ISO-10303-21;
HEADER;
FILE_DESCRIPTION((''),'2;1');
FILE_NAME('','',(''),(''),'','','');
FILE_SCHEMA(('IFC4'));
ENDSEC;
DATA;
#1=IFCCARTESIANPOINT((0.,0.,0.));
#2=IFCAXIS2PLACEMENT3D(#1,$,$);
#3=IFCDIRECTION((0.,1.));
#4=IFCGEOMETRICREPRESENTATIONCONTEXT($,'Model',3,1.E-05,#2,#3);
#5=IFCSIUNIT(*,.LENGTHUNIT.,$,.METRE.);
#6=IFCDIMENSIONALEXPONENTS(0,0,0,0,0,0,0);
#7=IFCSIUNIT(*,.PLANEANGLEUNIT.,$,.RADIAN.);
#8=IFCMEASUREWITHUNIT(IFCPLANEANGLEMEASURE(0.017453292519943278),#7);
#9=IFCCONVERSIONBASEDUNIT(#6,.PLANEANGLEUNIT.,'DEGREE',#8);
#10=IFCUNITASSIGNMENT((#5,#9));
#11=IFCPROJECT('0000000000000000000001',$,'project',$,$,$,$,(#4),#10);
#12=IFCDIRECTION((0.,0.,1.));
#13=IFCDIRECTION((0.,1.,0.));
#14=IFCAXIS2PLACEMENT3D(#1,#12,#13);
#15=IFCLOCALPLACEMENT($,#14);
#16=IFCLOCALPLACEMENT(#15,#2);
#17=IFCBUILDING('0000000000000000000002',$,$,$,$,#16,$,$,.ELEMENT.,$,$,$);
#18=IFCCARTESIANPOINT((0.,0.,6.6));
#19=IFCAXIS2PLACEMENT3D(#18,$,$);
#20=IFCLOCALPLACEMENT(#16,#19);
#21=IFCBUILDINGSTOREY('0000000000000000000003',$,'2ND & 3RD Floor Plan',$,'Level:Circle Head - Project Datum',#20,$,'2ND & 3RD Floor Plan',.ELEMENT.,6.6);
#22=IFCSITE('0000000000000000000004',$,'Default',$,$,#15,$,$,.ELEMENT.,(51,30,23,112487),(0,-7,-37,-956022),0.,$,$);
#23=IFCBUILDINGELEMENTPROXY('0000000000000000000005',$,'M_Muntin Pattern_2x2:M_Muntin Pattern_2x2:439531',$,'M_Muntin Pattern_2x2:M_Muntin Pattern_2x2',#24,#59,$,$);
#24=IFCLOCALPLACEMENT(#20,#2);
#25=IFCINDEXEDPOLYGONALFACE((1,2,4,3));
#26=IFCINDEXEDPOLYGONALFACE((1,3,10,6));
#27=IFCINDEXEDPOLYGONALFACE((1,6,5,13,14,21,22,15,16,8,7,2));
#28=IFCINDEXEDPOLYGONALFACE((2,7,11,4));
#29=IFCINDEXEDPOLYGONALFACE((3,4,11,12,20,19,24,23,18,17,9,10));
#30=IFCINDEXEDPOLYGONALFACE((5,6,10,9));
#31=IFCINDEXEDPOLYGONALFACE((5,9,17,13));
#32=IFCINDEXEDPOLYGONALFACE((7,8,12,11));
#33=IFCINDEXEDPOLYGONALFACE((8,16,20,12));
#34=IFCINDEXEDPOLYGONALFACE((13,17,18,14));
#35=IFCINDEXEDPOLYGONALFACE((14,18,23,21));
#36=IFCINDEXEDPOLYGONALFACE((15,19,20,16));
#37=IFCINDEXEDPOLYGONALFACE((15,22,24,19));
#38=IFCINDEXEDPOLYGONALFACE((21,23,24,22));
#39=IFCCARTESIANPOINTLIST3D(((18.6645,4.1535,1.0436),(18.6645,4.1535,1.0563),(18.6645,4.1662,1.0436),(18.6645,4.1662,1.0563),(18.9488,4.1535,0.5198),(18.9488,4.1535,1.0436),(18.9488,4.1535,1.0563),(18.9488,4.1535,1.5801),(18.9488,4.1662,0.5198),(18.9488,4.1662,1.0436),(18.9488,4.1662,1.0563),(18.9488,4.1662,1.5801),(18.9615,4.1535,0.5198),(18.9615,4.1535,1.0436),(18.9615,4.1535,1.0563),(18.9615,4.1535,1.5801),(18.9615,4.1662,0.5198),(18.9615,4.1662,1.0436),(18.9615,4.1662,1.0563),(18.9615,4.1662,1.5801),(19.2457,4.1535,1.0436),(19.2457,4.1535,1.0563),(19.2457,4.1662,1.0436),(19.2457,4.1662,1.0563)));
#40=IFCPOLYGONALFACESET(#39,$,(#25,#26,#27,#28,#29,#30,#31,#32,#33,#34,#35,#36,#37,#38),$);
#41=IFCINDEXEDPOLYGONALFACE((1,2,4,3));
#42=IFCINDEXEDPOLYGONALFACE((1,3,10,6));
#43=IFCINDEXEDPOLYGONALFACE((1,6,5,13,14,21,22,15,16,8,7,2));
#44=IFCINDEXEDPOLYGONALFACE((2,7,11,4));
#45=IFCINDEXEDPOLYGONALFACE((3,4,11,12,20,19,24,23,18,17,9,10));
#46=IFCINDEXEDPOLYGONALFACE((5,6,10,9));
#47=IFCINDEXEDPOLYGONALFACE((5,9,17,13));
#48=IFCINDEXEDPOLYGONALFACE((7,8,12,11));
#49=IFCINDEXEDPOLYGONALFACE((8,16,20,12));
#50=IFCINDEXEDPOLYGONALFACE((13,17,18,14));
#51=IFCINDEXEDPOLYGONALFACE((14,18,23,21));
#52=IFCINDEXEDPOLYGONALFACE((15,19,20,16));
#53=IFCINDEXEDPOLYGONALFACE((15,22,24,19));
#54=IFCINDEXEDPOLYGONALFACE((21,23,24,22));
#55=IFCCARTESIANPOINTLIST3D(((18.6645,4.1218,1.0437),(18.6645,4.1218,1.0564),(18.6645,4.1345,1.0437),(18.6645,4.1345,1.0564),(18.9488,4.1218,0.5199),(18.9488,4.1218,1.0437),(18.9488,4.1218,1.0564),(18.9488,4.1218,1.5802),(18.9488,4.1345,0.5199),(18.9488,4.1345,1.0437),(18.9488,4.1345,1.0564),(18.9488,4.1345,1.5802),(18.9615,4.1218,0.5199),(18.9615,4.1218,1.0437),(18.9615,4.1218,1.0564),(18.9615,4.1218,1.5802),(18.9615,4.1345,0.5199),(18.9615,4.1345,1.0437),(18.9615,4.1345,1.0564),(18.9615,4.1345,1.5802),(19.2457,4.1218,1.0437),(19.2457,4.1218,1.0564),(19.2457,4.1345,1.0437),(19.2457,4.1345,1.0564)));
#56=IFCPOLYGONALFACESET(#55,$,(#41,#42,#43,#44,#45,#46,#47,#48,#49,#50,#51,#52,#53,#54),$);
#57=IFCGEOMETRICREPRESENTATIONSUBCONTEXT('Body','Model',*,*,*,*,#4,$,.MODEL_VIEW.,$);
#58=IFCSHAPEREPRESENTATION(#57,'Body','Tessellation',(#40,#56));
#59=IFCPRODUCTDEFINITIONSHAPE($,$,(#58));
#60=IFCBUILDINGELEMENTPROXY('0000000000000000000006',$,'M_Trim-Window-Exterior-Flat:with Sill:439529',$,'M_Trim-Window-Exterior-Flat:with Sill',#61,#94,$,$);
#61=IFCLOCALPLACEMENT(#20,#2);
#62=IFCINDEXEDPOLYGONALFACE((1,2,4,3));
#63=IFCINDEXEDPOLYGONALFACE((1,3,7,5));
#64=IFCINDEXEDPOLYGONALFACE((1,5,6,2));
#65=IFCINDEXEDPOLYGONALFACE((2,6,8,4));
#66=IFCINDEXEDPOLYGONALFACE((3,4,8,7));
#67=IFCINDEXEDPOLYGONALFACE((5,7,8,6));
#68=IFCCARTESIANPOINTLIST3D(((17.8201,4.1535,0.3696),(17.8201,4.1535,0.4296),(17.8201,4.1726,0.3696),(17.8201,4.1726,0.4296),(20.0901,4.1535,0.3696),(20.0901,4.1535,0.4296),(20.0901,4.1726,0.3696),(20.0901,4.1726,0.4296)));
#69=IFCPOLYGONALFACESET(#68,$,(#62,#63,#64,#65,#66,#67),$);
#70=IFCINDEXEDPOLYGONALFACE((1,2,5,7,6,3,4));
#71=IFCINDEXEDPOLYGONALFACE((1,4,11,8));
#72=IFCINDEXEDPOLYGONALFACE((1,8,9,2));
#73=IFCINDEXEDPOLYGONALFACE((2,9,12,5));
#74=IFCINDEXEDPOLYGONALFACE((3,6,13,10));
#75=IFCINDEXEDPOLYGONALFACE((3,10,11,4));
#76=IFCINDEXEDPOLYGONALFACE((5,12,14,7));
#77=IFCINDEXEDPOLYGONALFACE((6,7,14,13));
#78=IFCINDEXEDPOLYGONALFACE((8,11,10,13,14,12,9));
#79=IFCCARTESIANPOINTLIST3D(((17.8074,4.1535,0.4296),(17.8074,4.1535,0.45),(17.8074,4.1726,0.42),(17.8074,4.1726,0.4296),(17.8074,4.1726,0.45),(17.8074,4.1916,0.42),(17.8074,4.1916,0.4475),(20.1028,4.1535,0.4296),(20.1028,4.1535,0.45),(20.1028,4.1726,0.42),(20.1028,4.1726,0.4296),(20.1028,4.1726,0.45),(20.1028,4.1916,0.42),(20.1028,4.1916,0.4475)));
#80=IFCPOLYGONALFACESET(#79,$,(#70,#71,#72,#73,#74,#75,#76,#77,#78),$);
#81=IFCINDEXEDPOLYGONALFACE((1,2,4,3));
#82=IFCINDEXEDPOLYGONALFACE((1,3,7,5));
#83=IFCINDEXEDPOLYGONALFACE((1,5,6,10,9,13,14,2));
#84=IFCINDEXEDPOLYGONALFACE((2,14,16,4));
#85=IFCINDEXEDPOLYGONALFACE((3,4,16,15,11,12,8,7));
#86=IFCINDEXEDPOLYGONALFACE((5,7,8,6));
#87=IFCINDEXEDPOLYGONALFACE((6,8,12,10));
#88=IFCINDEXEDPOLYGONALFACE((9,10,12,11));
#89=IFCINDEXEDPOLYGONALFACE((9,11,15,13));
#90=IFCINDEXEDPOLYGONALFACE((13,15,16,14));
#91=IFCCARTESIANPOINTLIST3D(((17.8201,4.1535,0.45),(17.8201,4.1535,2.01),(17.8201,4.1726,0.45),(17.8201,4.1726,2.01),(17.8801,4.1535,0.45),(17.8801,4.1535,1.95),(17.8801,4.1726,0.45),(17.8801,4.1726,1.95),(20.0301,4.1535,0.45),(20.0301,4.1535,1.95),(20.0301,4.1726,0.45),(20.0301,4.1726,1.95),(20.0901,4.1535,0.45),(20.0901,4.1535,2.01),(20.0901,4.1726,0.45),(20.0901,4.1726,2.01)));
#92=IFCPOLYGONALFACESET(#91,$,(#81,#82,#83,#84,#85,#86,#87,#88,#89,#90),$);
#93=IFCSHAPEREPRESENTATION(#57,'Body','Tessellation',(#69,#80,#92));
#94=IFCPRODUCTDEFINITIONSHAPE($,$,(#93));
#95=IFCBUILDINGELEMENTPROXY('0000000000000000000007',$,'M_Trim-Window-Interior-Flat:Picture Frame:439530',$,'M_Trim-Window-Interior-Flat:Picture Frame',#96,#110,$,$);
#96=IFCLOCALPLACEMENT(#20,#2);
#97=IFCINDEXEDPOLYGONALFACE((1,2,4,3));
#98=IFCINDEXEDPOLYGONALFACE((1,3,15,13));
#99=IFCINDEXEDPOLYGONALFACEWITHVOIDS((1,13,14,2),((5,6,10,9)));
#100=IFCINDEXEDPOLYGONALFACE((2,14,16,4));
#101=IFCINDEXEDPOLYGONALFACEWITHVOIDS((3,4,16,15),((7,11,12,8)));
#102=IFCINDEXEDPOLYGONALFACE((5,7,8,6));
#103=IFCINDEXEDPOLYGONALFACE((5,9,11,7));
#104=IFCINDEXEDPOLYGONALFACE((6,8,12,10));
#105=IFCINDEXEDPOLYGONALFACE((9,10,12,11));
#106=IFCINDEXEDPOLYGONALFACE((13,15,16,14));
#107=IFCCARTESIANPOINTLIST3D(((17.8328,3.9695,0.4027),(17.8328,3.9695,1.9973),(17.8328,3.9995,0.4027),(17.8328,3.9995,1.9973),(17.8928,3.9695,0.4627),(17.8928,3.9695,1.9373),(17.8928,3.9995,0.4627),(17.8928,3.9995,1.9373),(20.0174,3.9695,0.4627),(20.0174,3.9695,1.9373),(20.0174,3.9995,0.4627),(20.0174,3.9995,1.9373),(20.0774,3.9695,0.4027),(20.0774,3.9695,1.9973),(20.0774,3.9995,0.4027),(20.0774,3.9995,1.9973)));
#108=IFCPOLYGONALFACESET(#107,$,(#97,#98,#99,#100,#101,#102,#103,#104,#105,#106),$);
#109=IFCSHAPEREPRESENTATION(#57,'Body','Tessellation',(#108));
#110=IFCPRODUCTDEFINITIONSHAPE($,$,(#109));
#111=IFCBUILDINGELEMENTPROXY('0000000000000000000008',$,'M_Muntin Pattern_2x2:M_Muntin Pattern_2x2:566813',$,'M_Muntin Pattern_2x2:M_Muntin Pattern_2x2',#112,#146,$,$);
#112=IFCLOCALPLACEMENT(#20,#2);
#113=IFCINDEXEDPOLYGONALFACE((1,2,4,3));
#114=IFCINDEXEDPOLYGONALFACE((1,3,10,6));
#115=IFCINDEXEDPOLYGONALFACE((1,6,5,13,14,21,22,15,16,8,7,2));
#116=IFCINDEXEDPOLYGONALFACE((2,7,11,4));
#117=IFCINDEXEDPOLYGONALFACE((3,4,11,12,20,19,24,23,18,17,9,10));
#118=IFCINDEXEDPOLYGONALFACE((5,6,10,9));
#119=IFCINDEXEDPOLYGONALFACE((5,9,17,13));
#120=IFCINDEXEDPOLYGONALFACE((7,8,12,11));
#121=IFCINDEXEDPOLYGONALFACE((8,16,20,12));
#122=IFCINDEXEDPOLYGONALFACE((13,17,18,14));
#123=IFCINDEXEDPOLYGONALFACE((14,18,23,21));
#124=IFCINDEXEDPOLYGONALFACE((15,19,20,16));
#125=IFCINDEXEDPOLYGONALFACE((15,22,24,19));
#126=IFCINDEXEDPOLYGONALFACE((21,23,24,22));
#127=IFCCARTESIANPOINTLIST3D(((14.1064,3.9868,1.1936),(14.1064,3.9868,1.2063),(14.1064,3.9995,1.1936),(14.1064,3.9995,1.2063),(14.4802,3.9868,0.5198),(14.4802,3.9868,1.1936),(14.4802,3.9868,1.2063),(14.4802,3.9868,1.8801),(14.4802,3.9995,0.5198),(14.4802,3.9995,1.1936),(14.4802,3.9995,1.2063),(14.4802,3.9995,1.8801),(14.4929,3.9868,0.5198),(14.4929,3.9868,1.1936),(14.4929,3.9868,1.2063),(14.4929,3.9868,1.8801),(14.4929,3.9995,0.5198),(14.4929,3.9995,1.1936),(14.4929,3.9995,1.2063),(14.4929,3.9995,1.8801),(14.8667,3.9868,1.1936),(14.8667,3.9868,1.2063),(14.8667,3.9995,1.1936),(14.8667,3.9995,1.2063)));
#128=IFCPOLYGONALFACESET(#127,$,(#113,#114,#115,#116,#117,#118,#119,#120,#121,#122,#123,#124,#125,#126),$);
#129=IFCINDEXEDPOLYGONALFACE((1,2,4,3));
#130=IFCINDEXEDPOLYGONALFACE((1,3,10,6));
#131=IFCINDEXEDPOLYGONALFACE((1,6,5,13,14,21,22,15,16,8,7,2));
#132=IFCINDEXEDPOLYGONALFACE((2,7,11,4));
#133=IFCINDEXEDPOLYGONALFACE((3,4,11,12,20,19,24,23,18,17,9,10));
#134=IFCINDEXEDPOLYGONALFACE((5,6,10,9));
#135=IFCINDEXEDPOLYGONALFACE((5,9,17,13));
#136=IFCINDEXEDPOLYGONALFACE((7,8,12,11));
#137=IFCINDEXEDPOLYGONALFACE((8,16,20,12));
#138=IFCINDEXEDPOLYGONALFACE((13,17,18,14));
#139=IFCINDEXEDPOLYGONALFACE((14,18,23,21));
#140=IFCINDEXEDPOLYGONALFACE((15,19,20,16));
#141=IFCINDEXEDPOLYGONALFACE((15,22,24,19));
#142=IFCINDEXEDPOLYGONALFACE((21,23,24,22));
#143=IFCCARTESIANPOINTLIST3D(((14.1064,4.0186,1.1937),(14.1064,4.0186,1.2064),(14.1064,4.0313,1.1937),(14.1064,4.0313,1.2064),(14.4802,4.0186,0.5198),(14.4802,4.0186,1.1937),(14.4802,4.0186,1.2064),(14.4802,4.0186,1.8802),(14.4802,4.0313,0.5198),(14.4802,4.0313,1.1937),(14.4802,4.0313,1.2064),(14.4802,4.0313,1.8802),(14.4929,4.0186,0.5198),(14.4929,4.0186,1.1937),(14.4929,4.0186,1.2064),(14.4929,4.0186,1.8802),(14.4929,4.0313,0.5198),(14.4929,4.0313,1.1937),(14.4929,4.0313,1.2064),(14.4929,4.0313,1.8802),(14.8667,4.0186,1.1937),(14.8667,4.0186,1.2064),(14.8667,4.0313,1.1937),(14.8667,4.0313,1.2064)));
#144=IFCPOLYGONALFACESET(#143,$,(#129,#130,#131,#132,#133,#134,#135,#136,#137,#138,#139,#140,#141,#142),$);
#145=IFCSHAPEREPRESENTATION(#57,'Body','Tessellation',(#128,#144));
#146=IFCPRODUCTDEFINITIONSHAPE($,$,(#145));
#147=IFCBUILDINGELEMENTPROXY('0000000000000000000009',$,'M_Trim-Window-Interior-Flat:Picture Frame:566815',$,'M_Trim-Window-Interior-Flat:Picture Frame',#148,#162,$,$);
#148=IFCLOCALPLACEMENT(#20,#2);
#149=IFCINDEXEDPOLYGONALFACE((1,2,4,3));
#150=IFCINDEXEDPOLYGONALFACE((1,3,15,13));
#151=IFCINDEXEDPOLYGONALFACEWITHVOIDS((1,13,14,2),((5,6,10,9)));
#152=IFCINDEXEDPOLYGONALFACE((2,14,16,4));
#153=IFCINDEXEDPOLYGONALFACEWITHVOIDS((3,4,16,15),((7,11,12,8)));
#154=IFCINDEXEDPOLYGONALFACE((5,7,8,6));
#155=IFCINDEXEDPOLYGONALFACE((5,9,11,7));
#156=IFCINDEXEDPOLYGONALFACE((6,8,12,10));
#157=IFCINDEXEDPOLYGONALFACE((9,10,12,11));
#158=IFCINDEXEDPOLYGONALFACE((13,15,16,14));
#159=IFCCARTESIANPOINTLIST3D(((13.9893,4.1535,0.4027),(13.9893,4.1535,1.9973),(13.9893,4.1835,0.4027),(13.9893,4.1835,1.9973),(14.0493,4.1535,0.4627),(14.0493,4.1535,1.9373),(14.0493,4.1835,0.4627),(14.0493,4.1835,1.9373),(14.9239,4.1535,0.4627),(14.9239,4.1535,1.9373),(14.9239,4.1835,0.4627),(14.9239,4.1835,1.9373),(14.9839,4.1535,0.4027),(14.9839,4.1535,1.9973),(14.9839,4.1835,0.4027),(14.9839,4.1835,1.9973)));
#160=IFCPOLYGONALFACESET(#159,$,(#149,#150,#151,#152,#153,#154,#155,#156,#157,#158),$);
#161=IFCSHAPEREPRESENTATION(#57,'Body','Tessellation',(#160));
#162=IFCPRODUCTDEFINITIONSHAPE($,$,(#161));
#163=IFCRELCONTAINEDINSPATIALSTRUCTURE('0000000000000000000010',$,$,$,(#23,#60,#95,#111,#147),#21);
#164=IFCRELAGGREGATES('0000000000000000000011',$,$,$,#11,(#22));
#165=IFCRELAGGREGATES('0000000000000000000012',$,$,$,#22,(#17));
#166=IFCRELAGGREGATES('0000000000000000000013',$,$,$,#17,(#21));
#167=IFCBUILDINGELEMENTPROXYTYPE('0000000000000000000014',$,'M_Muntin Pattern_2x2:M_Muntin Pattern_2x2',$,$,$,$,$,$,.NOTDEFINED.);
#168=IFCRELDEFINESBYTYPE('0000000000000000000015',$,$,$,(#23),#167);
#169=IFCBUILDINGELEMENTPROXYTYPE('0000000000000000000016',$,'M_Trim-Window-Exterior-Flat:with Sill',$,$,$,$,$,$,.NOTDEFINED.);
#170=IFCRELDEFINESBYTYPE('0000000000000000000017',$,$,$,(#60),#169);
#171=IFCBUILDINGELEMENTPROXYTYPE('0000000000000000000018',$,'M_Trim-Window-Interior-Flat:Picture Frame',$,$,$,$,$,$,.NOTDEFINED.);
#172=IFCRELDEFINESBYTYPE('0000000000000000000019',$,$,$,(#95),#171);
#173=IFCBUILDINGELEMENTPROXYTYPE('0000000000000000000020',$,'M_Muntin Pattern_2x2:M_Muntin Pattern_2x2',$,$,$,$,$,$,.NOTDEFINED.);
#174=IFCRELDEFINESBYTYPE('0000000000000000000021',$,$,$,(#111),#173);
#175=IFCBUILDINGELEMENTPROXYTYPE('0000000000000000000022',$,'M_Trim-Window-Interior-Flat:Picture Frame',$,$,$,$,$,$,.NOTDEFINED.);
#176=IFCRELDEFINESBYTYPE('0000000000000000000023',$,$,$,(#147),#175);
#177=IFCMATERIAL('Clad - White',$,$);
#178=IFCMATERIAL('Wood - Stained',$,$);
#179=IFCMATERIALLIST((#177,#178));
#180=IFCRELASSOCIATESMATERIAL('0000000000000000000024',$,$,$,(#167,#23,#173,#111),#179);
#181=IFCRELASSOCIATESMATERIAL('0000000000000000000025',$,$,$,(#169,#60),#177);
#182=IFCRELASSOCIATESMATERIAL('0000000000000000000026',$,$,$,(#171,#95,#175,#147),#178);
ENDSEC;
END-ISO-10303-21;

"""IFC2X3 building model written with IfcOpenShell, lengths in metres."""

from ifc_helpers import new_model, entity, si_unit, converted_unit, direction, frame, frame_2d, origin, place, context, subcontext, project, spatial, polyline, rectangle, outline, extrude, source, transform, mapped, material, material_list, type_object, type_shapes, element, save


model = new_model("IFC2X3")

# Units and contexts
model_context = context("Model", 3, precision=1e-05, world=origin(), true_north=direction((0.0, 1.0)))
body_context = subcontext(model_context, "Body", "Model", "MODEL_VIEW")
ifc_project = project(units=[si_unit("LENGTHUNIT", "METRE"), converted_unit("PLANEANGLEUNIT", "DEGREE", entity("IfcPlaneAngleMeasure", 0.017453292519943278), si_unit("PLANEANGLEUNIT", "RADIAN"), dimensions=[0, 0, 0, 0, 0, 0, 0])], contexts=[model_context])

# Site, building, storey
site_placement = place(None, frame((0.0, 0.0, 0.0), z_axis=(0.0, 0.0, 1.0), x_axis=(0.0, 1.0, 0.0)))
site = spatial("IfcSite", under=ifc_project, at=site_placement, Name="Default", CompositionType="ELEMENT", RefLatitude=(51, 30, 23, 112487), RefLongitude=(0, -7, -37, -956022), RefElevation=0.0)
building_placement = place(site_placement, origin())
building = spatial("IfcBuilding", under=site, at=building_placement, CompositionType="ELEMENT")
storey_placement = place(building_placement, frame((0.0, 0.0, 6.6)))
storey = spatial("IfcBuildingStorey", under=building, at=storey_placement, Name="2ND & 3RD Floor Plan", ObjectType="Level:Circle Head - Project Datum", LongName="2ND & 3RD Floor Plan", CompositionType="ELEMENT", Elevation=6.6)

# Building element proxies
ifc_material_1 = material(Name="Clad - White")
ifc_material_2 = material(Name="Wood - Stained")
ifc_material_list = material_list([ifc_material_1, ifc_material_2])
building_element_proxy_type_1 = type_object("IfcBuildingElementProxyType", Name="M_Muntin Pattern_2x2:M_Muntin Pattern_2x2", PredefinedType="NOTDEFINED", material=ifc_material_list)
shared_shape_1 = source(origin(), body_context, "Body", "SweptSolid", [
    extrude(outline(polyline([(0.0064, -0.0064), (0.5301, -0.0064), (0.5301, 0.0063), (0.0064, 0.0063), (0.0064, 0.2906), (-0.0063, 0.2906), (-0.0063, 0.0063), (-0.5302, 0.0063), (-0.5302, -0.0064), (-0.0063, -0.0064), (-0.0063, -0.2906), (0.0064, -0.2906), (0.0064, -0.0064)])), frame((0.0, -0.0222, 0.5301), z_axis=(0.0, 1.0, 0.0), x_axis=(0.0, 0.0, 1.0)), (0.0, 0.0, 1.0), 0.0127),
    extrude(outline(polyline([(0.0064, -0.0064), (0.5302, -0.0064), (0.5302, 0.0063), (0.0064, 0.0063), (0.0064, 0.2906), (-0.0063, 0.2906), (-0.0063, 0.0063), (-0.5302, 0.0063), (-0.5302, -0.0064), (-0.0063, -0.0064), (-0.0063, -0.2906), (0.0064, -0.2906), (0.0064, -0.0064)])), frame((0.0, 0.0095, 0.5302), z_axis=(0.0, 1.0, 0.0), x_axis=(0.0, 0.0, 1.0)), (0.0, 0.0, 1.0), 0.0127),
])
type_shapes(building_element_proxy_type_1, [shared_shape_1])
for number, where, z_axis, x_axis, name in (
    (1, (18.9551, 4.144, 0.5199), (0.0, 0.0, 1.0), (-1.0, 0.0, 0.0), "M_Muntin Pattern_2x2:M_Muntin Pattern_2x2:439531"),
):
    element("IfcBuildingElementProxy", number, at=place(storey_placement, frame(where, z_axis=z_axis, x_axis=x_axis)), inside=storey, type_object=building_element_proxy_type_1, material=ifc_material_list, Name=name, ObjectType="M_Muntin Pattern_2x2:M_Muntin Pattern_2x2", context=body_context, shape_type="MappedRepresentation", body=[
        mapped(shared_shape_1, transform((0.0, 0.0, 0.0), scale=1.0)),
    ])
building_element_proxy_type_2 = type_object("IfcBuildingElementProxyType", Name="M_Trim-Window-Exterior-Flat:with Sill", PredefinedType="NOTDEFINED", material=ifc_material_1)
shared_shape_2 = source(origin(), body_context, "Body", "SweptSolid", [
    extrude(rectangle(XDim=2.27, YDim=0.06, at=frame_2d((0.0, 0.0), x_axis=(1.0, 0.0))), frame((0.0, -1.5504, 0.0), z_axis=(0.0, 0.0, 1.0), x_axis=(-1.0, 0.0, 0.0)), (0.0, 0.0, 1.0), 0.019),
    extrude(outline(polyline([(-0.019, -0.0152), (0.0, -0.0152), (0.0, -0.0057), (0.019, -0.0057), (0.019, 0.0148), (0.0, 0.0148), (-0.019, 0.0123), (-0.019, -0.0152)])), frame((-1.1477, -1.5148, 0.019), z_axis=(1.0, 0.0, 0.0), x_axis=(0.0, 0.0, -1.0)), (0.0, 0.0, 1.0), 2.2954),
    extrude(outline(polyline([(-0.795, -1.135), (0.765, -1.135), (0.765, -1.075), (-0.735, -1.075), (-0.735, 1.075), (0.765, 1.075), (0.765, 1.135), (-0.795, 1.135), (-0.795, -1.135)])), frame((0.0, -0.735, 0.0), z_axis=(0.0, 0.0, 1.0), x_axis=(0.0, -1.0, 0.0)), (0.0, 0.0, 1.0), 0.019),
])
type_shapes(building_element_proxy_type_2, [shared_shape_2])
proxy_1_placement = place(storey_placement, frame((18.9551, 4.1535, 1.95), z_axis=(0.0, 1.0, 0.0), x_axis=(-1.0, 0.0, 0.0)))
element("IfcBuildingElementProxy", 2, at=proxy_1_placement, inside=storey, type_object=building_element_proxy_type_2, material=ifc_material_1, Name="M_Trim-Window-Exterior-Flat:with Sill:439529", ObjectType="M_Trim-Window-Exterior-Flat:with Sill", context=body_context, shape_type="MappedRepresentation", body=[
    mapped(shared_shape_2, transform((0.0, 0.0, 0.0), scale=1.0)),
])
building_element_proxy_type_3 = type_object("IfcBuildingElementProxyType", Name="M_Trim-Window-Interior-Flat:Picture Frame", PredefinedType="NOTDEFINED", material=ifc_material_2)
shared_shape_3 = source(origin(), body_context, "Body", "SweptSolid", [
    extrude(outline(polyline([(-1.1223, -0.7973), (1.1223, -0.7973), (1.1223, 0.7973), (-1.1223, 0.7973), (-1.1223, -0.7973)]), holes=[polyline([(-1.0623, -0.7373), (-1.0623, 0.7373), (1.0623, 0.7373), (1.0623, -0.7373), (-1.0623, -0.7373)])]), frame((0.0, -0.75, 0.0), z_axis=(0.0, 0.0, 1.0), x_axis=(-1.0, 0.0, 0.0)), (0.0, 0.0, 1.0), 0.03),
])
type_shapes(building_element_proxy_type_3, [shared_shape_3])
proxy_2_placement = place(storey_placement, frame((18.9551, 3.9995, 1.95), z_axis=(0.0, -1.0, 0.0), x_axis=(1.0, 0.0, 0.0)))
element("IfcBuildingElementProxy", 3, at=proxy_2_placement, inside=storey, type_object=building_element_proxy_type_3, material=ifc_material_2, Name="M_Trim-Window-Interior-Flat:Picture Frame:439530", ObjectType="M_Trim-Window-Interior-Flat:Picture Frame", context=body_context, shape_type="MappedRepresentation", body=[
    mapped(shared_shape_3, transform((0.0, 0.0, 0.0), scale=1.0)),
])
building_element_proxy_type_4 = type_object("IfcBuildingElementProxyType", Name="M_Muntin Pattern_2x2:M_Muntin Pattern_2x2", PredefinedType="NOTDEFINED", material=ifc_material_list)
shared_shape_4 = source(origin(), body_context, "Body", "SweptSolid", [
    extrude(outline(polyline([(0.0064, -0.0064), (0.6801, -0.0064), (0.6801, 0.0063), (0.0064, 0.0063), (0.0064, 0.3802), (-0.0063, 0.3802), (-0.0063, 0.0063), (-0.6802, 0.0063), (-0.6802, -0.0064), (-0.0063, -0.0064), (-0.0063, -0.3801), (0.0064, -0.3801), (0.0064, -0.0064)])), frame((0.0, 0.0095, 0.6801), z_axis=(0.0, 1.0, 0.0), x_axis=(0.0, 0.0, 1.0)), (0.0, 0.0, 1.0), 0.0127),
    extrude(outline(polyline([(0.0064, -0.0064), (0.6802, -0.0064), (0.6802, 0.0063), (0.0064, 0.0063), (0.0064, 0.3802), (-0.0063, 0.3802), (-0.0063, 0.0063), (-0.6802, 0.0063), (-0.6802, -0.0064), (-0.0063, -0.0064), (-0.0063, -0.3801), (0.0064, -0.3801), (0.0064, -0.0064)])), frame((0.0, -0.0222, 0.6802), z_axis=(0.0, 1.0, 0.0), x_axis=(0.0, 0.0, 1.0)), (0.0, 0.0, 1.0), 0.0127),
])
type_shapes(building_element_proxy_type_4, [shared_shape_4])
proxy_3_placement = place(storey_placement, frame((14.4866, 4.0091, 0.5198), z_axis=(0.0, 0.0, 1.0), x_axis=(-1.0, 0.0, 0.0)))
element("IfcBuildingElementProxy", 4, at=proxy_3_placement, inside=storey, type_object=building_element_proxy_type_4, material=ifc_material_list, Name="M_Muntin Pattern_2x2:M_Muntin Pattern_2x2:566813", ObjectType="M_Muntin Pattern_2x2:M_Muntin Pattern_2x2", context=body_context, shape_type="MappedRepresentation", body=[
    mapped(shared_shape_4, transform((0.0, 0.0, 0.0), scale=1.0)),
])
building_element_proxy_type_5 = type_object("IfcBuildingElementProxyType", Name="M_Trim-Window-Interior-Flat:Picture Frame", PredefinedType="NOTDEFINED", material=ifc_material_2)
shared_shape_5 = source(origin(), body_context, "Body", "SweptSolid", [
    extrude(outline(polyline([(-0.4973, -0.7973), (0.4973, -0.7973), (0.4973, 0.7973), (-0.4973, 0.7973), (-0.4973, -0.7973)]), holes=[polyline([(-0.4373, -0.7373), (-0.4373, 0.7373), (0.4373, 0.7373), (0.4373, -0.7373), (-0.4373, -0.7373)])]), frame((0.0, -0.75, 0.0), z_axis=(0.0, 0.0, 1.0), x_axis=(-1.0, 0.0, 0.0)), (0.0, 0.0, 1.0), 0.03),
])
type_shapes(building_element_proxy_type_5, [shared_shape_5])
proxy_4_placement = place(storey_placement, frame((14.4866, 4.1535, 1.95), z_axis=(0.0, 1.0, 0.0), x_axis=(-1.0, 0.0, 0.0)))
element("IfcBuildingElementProxy", 5, at=proxy_4_placement, inside=storey, type_object=building_element_proxy_type_5, material=ifc_material_2, Name="M_Trim-Window-Interior-Flat:Picture Frame:566815", ObjectType="M_Trim-Window-Interior-Flat:Picture Frame", context=body_context, shape_type="MappedRepresentation", body=[
    mapped(shared_shape_5, transform((0.0, 0.0, 0.0), scale=1.0)),
])

save(model, "model.ifc")
